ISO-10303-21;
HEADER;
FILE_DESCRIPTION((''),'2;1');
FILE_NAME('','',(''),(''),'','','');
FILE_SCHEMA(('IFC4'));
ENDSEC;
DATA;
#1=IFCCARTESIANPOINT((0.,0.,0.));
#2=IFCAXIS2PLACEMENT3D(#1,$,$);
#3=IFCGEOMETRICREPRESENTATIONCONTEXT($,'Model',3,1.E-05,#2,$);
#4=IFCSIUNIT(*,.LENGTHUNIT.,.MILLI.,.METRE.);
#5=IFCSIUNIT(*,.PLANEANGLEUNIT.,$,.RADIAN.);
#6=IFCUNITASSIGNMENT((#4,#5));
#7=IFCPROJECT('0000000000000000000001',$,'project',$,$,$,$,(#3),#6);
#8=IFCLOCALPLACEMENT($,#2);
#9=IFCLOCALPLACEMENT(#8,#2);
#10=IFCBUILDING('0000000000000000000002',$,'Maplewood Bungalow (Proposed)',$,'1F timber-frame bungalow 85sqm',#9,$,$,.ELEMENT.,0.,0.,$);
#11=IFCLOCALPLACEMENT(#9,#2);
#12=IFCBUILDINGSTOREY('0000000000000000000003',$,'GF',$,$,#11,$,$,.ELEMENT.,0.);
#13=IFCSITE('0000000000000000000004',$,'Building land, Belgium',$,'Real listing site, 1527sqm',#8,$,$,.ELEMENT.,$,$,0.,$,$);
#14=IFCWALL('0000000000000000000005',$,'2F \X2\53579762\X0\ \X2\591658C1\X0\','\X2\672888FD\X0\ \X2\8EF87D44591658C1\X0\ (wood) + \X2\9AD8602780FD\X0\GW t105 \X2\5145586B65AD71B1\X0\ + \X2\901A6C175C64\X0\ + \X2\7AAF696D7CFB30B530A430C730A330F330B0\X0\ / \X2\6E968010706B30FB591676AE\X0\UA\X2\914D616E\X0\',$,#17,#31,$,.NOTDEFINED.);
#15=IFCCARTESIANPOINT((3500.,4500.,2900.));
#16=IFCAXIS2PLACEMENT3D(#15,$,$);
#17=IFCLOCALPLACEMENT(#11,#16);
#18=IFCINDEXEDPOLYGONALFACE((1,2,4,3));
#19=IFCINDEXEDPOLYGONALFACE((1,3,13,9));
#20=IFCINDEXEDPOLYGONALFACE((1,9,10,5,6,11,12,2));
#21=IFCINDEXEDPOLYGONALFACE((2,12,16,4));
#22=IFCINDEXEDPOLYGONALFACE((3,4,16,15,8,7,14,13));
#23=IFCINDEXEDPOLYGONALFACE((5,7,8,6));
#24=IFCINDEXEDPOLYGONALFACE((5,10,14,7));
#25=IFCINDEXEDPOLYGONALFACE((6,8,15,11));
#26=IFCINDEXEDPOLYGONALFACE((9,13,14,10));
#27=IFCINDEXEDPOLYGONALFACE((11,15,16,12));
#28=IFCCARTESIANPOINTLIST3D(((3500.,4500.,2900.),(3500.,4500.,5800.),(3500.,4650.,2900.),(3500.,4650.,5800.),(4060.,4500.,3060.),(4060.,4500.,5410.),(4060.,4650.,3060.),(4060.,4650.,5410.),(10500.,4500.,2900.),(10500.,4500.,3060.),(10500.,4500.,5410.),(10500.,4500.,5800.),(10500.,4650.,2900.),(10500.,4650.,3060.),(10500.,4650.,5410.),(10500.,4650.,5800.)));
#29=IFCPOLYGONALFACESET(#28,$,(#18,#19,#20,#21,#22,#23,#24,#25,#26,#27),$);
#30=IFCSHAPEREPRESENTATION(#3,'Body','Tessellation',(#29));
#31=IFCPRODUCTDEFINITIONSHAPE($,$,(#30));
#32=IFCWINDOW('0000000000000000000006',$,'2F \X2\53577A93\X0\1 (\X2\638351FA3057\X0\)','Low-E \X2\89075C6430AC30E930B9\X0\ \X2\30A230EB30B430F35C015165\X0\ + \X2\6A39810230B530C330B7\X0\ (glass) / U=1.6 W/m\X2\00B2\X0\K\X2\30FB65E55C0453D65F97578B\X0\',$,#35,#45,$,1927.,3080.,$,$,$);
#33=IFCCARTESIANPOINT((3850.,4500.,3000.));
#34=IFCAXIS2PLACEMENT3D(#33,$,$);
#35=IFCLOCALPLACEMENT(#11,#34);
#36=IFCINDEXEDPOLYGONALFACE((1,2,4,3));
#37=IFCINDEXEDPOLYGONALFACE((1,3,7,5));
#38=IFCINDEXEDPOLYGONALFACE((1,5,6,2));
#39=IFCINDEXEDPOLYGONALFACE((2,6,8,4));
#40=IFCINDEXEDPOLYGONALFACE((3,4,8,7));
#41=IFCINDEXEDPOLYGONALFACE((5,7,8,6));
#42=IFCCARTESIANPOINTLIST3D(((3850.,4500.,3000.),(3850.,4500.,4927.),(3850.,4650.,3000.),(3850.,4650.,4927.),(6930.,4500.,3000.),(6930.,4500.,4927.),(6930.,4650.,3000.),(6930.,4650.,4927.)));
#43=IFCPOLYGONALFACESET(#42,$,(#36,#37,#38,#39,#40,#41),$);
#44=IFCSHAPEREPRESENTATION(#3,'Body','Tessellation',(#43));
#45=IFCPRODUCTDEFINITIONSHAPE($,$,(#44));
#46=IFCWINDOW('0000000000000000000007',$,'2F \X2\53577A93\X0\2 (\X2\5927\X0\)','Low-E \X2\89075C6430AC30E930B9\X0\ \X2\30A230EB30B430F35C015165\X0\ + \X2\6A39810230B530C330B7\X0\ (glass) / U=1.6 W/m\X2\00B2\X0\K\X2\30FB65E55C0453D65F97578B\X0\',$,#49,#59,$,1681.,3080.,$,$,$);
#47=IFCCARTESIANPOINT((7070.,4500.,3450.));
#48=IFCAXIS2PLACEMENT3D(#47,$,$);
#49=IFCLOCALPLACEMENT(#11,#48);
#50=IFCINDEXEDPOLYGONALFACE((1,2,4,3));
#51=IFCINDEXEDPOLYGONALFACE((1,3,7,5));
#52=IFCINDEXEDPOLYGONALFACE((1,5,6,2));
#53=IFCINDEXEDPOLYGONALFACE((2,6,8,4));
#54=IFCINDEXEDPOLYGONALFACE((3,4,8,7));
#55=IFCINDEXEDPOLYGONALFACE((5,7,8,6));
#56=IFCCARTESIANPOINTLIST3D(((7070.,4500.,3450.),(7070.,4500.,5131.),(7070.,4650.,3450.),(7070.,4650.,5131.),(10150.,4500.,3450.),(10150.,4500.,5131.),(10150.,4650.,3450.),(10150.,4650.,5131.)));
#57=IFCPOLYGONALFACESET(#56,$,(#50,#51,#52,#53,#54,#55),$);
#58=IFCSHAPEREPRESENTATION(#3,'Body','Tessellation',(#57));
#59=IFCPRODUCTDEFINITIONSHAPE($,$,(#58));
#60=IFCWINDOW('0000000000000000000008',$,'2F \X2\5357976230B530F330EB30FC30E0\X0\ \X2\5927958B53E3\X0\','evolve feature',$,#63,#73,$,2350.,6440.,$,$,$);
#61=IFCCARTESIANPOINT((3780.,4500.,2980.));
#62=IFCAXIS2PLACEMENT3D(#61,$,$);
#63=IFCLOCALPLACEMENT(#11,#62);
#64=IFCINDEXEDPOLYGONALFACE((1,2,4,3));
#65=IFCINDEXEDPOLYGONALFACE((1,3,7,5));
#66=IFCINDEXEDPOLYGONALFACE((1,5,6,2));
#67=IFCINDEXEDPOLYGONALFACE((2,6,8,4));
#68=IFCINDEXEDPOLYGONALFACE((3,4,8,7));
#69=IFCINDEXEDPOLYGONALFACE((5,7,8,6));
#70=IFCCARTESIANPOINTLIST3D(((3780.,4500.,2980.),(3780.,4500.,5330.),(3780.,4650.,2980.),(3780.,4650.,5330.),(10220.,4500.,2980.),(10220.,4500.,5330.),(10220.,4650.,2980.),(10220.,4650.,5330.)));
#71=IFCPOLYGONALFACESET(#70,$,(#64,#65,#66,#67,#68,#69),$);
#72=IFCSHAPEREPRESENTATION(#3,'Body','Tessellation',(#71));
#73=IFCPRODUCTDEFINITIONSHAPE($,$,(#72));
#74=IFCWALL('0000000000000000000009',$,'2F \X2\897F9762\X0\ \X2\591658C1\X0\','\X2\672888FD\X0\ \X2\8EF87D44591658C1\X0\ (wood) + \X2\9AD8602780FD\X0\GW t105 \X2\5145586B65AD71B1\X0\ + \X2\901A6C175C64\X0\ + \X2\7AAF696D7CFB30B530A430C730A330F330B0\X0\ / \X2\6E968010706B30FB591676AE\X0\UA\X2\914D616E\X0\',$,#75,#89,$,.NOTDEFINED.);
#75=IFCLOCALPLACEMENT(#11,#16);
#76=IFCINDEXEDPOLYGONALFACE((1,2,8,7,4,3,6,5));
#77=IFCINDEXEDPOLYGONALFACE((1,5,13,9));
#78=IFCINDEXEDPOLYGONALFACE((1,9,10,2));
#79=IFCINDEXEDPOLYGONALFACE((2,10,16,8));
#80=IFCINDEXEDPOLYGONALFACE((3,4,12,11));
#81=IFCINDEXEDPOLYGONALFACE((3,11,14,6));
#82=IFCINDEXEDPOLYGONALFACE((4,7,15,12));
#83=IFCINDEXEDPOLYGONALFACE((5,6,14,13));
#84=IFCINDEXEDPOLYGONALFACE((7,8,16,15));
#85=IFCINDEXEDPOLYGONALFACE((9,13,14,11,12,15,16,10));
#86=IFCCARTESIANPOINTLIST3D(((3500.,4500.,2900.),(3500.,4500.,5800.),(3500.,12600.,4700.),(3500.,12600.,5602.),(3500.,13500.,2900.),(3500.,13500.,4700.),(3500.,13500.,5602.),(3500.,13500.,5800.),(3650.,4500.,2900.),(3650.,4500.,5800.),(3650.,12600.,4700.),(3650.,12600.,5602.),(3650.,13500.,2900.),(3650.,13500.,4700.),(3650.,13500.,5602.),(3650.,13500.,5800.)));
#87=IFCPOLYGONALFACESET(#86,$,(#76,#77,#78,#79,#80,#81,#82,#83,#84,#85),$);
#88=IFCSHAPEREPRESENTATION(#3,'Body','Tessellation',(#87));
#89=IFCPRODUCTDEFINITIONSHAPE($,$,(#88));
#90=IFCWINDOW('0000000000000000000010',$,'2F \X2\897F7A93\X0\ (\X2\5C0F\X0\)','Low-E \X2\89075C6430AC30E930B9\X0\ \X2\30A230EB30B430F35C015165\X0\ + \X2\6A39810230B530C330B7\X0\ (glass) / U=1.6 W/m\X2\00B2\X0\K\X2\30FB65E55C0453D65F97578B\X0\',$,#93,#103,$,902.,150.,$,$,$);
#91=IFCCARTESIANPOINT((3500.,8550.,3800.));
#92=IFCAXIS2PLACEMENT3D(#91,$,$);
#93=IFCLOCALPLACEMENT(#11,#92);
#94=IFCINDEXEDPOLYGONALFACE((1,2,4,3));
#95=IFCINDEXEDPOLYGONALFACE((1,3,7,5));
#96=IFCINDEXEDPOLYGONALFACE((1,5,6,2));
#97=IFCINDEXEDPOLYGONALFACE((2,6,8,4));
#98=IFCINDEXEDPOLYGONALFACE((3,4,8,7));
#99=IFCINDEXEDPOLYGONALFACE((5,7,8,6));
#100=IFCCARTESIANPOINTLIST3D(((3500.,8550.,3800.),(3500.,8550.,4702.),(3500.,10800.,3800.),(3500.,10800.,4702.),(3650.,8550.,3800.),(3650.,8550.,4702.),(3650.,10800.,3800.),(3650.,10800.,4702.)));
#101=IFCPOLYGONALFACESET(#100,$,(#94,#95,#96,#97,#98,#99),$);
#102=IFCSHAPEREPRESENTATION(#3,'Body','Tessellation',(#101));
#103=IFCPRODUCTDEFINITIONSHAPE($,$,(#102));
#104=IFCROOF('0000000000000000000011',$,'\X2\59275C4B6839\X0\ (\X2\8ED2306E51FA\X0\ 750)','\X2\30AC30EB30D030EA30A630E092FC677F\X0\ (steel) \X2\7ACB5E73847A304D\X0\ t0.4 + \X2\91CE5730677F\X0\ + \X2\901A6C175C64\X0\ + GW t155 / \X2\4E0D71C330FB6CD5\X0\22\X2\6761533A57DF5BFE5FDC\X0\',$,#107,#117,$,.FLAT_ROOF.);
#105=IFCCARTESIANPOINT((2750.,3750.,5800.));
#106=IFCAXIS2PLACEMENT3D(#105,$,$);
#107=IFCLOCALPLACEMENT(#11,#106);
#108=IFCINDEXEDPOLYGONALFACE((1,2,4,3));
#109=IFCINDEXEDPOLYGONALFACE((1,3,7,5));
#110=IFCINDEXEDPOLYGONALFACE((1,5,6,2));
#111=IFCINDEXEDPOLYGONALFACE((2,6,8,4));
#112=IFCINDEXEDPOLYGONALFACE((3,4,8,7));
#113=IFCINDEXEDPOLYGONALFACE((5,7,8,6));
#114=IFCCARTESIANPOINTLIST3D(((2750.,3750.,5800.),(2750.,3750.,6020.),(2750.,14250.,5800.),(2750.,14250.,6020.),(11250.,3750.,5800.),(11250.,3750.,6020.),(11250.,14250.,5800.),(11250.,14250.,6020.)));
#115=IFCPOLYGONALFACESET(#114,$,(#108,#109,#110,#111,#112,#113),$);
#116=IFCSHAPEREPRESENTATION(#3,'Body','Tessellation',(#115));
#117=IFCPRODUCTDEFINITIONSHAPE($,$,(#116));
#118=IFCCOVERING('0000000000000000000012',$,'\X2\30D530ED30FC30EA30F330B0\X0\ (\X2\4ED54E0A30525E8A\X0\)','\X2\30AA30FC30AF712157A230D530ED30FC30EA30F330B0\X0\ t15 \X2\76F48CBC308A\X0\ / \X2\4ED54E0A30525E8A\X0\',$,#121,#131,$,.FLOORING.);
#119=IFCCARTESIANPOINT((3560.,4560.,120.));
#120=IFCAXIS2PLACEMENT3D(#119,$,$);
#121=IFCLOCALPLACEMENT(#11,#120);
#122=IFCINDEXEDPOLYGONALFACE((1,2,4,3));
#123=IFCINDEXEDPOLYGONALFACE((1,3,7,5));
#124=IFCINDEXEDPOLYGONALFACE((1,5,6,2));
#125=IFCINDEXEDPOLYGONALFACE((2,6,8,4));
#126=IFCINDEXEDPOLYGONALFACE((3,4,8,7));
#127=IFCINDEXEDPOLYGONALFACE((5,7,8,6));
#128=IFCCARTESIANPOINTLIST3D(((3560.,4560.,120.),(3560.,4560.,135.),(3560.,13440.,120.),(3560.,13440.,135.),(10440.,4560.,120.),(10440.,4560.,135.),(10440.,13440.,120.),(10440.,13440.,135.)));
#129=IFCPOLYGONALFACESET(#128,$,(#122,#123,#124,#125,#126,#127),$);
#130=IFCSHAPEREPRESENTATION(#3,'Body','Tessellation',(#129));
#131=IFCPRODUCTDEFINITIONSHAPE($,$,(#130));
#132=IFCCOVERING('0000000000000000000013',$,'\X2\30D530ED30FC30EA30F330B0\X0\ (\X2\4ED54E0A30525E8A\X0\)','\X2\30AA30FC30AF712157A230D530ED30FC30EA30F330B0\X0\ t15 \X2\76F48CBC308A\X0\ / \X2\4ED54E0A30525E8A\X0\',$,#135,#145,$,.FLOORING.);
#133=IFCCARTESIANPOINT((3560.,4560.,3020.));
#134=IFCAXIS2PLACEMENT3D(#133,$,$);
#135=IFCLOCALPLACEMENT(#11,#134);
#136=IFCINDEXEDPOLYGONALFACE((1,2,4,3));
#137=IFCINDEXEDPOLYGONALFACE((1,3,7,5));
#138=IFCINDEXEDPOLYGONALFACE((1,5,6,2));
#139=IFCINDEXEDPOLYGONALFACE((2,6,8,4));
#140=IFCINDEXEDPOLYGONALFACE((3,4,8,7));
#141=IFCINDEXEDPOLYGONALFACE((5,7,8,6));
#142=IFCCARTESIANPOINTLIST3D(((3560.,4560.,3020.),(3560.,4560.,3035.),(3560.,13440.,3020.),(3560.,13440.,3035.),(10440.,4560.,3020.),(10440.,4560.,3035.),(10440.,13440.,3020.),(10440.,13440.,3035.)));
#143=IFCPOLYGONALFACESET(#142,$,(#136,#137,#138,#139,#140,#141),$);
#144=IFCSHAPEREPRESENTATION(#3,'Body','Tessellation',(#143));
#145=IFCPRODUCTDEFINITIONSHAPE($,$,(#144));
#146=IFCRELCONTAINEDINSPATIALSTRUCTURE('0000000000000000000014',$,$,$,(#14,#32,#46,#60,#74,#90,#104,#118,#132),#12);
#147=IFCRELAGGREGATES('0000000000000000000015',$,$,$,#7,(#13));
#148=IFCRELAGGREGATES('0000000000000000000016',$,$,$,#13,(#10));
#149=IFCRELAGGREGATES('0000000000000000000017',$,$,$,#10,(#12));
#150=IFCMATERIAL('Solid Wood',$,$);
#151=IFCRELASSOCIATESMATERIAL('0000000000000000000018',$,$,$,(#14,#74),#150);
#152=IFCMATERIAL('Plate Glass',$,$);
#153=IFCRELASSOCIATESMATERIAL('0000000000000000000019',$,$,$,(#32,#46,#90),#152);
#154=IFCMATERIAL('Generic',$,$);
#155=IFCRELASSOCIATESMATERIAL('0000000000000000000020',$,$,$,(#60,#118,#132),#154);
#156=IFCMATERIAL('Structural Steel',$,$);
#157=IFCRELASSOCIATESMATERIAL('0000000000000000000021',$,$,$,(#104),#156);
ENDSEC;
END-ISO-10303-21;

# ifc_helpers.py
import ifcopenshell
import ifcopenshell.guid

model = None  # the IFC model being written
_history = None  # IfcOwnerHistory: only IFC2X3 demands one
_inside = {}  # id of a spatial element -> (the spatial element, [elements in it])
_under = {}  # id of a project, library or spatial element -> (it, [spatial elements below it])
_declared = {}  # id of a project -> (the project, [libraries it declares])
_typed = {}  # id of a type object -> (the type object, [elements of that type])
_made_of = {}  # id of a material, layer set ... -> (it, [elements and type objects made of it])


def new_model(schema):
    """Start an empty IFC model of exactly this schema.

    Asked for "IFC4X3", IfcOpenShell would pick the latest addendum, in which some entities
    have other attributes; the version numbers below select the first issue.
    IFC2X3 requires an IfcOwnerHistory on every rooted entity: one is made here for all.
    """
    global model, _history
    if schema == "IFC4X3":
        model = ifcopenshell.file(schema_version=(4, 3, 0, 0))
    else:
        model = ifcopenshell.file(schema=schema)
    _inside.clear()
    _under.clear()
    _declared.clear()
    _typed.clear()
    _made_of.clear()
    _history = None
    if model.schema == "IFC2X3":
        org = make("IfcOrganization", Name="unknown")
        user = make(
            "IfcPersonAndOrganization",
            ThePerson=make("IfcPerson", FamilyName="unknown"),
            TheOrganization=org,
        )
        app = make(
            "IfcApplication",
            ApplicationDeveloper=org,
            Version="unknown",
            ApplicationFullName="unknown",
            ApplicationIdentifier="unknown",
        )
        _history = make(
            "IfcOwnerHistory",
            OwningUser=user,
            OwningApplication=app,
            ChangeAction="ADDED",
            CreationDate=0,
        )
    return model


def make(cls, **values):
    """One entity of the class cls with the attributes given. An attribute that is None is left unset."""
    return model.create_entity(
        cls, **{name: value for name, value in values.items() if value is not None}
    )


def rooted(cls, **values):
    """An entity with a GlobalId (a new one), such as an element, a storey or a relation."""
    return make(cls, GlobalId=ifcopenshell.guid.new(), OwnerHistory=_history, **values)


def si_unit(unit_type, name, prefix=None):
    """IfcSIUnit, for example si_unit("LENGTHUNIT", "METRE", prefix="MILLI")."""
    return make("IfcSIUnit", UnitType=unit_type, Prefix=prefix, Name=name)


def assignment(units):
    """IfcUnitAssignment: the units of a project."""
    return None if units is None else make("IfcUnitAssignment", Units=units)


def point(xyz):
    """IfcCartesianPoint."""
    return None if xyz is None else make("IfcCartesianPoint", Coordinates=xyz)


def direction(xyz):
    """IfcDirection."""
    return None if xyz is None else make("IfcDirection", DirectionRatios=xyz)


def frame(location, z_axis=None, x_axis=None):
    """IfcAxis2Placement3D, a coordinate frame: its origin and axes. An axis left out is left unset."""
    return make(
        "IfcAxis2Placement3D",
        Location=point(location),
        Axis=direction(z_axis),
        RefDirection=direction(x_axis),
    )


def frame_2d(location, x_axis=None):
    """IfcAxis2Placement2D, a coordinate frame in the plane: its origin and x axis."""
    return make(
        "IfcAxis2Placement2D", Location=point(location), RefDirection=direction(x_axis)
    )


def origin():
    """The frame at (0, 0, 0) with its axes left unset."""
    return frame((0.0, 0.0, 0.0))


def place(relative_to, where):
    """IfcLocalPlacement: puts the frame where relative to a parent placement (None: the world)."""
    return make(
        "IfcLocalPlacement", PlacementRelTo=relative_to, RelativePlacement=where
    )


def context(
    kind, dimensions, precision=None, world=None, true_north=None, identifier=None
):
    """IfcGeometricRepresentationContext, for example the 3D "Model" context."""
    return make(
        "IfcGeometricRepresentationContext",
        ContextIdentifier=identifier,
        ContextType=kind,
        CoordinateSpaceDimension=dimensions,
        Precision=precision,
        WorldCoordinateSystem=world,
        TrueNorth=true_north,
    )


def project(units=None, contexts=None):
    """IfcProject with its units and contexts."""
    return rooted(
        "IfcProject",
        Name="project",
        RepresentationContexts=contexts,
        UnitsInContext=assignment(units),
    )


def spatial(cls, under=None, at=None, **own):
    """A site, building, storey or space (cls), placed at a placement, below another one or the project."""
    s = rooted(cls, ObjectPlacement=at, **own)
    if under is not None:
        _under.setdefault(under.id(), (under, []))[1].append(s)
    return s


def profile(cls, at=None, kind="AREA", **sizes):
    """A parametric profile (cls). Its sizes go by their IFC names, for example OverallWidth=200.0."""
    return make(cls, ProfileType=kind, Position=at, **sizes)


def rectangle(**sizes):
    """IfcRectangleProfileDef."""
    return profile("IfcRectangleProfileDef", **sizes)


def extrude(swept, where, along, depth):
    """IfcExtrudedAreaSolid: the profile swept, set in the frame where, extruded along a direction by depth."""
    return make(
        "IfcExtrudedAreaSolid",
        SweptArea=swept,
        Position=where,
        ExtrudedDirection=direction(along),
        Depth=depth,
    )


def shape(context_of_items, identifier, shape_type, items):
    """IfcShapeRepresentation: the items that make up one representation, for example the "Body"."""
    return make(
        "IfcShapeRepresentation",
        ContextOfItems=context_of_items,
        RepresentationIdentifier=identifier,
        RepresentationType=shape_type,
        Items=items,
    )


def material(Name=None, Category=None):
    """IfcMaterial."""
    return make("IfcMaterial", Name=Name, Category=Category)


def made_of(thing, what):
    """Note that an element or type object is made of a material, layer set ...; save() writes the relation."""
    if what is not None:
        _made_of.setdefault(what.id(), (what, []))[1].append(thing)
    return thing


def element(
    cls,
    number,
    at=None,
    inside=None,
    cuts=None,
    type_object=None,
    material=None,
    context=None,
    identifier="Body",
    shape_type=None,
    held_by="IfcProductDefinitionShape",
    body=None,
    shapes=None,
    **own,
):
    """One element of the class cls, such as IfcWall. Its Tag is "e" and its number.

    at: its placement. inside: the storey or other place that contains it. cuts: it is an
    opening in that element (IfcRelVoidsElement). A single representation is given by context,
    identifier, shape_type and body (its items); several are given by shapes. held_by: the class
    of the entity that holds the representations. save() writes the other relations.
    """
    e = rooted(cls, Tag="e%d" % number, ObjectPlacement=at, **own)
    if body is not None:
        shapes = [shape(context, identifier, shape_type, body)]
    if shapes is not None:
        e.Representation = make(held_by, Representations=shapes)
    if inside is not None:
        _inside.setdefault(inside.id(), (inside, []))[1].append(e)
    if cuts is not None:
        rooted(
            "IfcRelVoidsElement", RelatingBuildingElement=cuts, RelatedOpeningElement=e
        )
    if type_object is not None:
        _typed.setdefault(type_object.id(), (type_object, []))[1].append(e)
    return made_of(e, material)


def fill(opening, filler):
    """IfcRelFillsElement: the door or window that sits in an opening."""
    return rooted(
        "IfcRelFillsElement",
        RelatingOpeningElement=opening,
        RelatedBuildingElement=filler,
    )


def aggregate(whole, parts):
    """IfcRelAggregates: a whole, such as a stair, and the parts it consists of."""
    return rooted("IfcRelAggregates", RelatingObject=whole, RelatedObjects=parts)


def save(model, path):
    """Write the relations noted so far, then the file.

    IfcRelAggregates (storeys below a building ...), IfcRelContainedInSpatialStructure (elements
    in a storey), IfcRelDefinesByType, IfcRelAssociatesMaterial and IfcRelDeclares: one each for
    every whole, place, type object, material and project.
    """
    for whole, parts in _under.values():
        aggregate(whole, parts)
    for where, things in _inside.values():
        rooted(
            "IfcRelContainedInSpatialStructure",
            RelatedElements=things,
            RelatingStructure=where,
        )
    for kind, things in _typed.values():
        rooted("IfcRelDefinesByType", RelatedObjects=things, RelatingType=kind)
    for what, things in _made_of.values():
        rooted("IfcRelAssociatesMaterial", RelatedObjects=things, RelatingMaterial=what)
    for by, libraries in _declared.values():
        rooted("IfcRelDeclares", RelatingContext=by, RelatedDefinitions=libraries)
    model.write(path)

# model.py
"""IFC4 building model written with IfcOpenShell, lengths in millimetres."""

from ifc_helpers import new_model, si_unit, frame, frame_2d, origin, place, context, project, spatial, rectangle, extrude, material, element, fill, save


model = new_model("IFC4")

# Units and contexts
model_context = context("Model", 3, precision=1e-05, world=origin())
ifc_project = project(units=[si_unit("LENGTHUNIT", "METRE", prefix="MILLI"), si_unit("PLANEANGLEUNIT", "RADIAN")], contexts=[model_context])

# Site, building, storey
site_placement = place(None, origin())
site = spatial("IfcSite", under=ifc_project, at=site_placement, Name="Building land, Belgium", ObjectType="Real listing site, 1527sqm", CompositionType="ELEMENT", RefElevation=0.0)
building_placement = place(site_placement, origin())
building = spatial("IfcBuilding", under=site, at=building_placement, Name="Maplewood Bungalow (Proposed)", ObjectType="1F timber-frame bungalow 85sqm", CompositionType="ELEMENT", ElevationOfRefHeight=0.0, ElevationOfTerrain=0.0)
storey_placement = place(building_placement, origin())
storey = spatial("IfcBuildingStorey", under=building, at=storey_placement, Name="GF", CompositionType="ELEMENT", Elevation=0.0)

# Shared definitions
ifc_material_1 = material(Name="Solid Wood")
ifc_material_2 = material(Name="Generic")

# Shared definitions
ifc_material_3 = material(Name="Plate Glass")

# Wall, openings, windows
wall_1_placement = place(storey_placement, frame((3500.0, 4500.0, 2900.0)))
wall_1 = element("IfcWall", 1, at=wall_1_placement, inside=storey, material=ifc_material_1, Name="2F 南面 外壁", Description="木製 軸組外壁 (wood) + 高性能GW t105 充填断熱 + 通気層 + 窯業系サイディング / 準耐火・外皮UA配慮", PredefinedType="NOTDEFINED", context=model_context, shape_type="SweptSolid", body=[
    extrude(rectangle(XDim=7000.0, YDim=150.0, at=frame_2d((3500.0, 75.0))), frame((3500.0, 4500.0, 2900.0)), (0.0, 0.0, 1.0), 2900.0),
])
opening_1_placement = place(storey_placement, frame((3850.0, 4500.0, 3000.0)))
opening_1 = element("IfcOpeningElement", 2, at=opening_1_placement, cuts=wall_1, PredefinedType="NOTDEFINED", context=model_context, shape_type="SweptSolid", body=[
    extrude(rectangle(XDim=3080.0, YDim=150.0, at=frame_2d((1540.0, 75.0))), frame((3850.0, 4500.0, 3000.0)), (0.0, 0.0, 1.0), 1927.0),
])
opening_2_placement = place(storey_placement, frame((7070.0, 4500.0, 3450.0)))
opening_2 = element("IfcOpeningElement", 3, at=opening_2_placement, cuts=wall_1, PredefinedType="NOTDEFINED", context=model_context, shape_type="SweptSolid", body=[
    extrude(rectangle(XDim=3080.0, YDim=150.0, at=frame_2d((1540.0, 75.0))), frame((7070.0, 4500.0, 3450.0)), (0.0, 0.0, 1.0), 1681.0),
])
opening_3_placement = place(storey_placement, frame((3780.0, 4500.0, 2980.0)))
opening_3 = element("IfcOpeningElement", 4, at=opening_3_placement, cuts=wall_1, PredefinedType="NOTDEFINED", context=model_context, shape_type="SweptSolid", body=[
    extrude(rectangle(XDim=6440.0, YDim=150.0, at=frame_2d((3220.0, 75.0))), frame((3780.0, 4500.0, 2980.0)), (0.0, 0.0, 1.0), 2350.0),
])
window_1_placement = place(storey_placement, frame((3850.0, 4500.0, 3000.0)))
window_1 = element("IfcWindow", 5, at=window_1_placement, inside=storey, material=ifc_material_3, Name="2F 南窓1 (掃出し)", Description="Low-E 複層ガラス アルゴン封入 + 樹脂サッシ (glass) / U=1.6 W/m²K・日射取得型", OverallHeight=1927.0, OverallWidth=3080.0, context=model_context, shape_type="SweptSolid", body=[
    extrude(rectangle(XDim=3080.0, YDim=150.0, at=frame_2d((1540.0, 75.0))), frame((3850.0, 4500.0, 3000.0)), (0.0, 0.0, 1.0), 1927.0),
])
fill(opening_1, window_1)
window_2_placement = place(storey_placement, frame((7070.0, 4500.0, 3450.0)))
window_2 = element("IfcWindow", 6, at=window_2_placement, inside=storey, material=ifc_material_3, Name="2F 南窓2 (大)", Description="Low-E 複層ガラス アルゴン封入 + 樹脂サッシ (glass) / U=1.6 W/m²K・日射取得型", OverallHeight=1681.0, OverallWidth=3080.0, context=model_context, shape_type="SweptSolid", body=[
    extrude(rectangle(XDim=3080.0, YDim=150.0, at=frame_2d((1540.0, 75.0))), frame((7070.0, 4500.0, 3450.0)), (0.0, 0.0, 1.0), 1681.0),
])
fill(opening_2, window_2)
window_3_placement = place(storey_placement, frame((3780.0, 4500.0, 2980.0)))
window_3 = element("IfcWindow", 7, at=window_3_placement, inside=storey, material=ifc_material_2, Name="2F 南面サンルーム 大開口", Description="evolve feature", OverallHeight=2350.0, OverallWidth=6440.0, context=model_context, shape_type="SweptSolid", body=[
    extrude(rectangle(XDim=6440.0, YDim=150.0, at=frame_2d((3220.0, 75.0))), frame((3780.0, 4500.0, 2980.0)), (0.0, 0.0, 1.0), 2350.0),
])
fill(opening_3, window_3)

# Wall, opening, window
wall_2_placement = place(storey_placement, frame((3500.0, 4500.0, 2900.0)))
wall_2 = element("IfcWall", 8, at=wall_2_placement, inside=storey, material=ifc_material_1, Name="2F 西面 外壁", Description="木製 軸組外壁 (wood) + 高性能GW t105 充填断熱 + 通気層 + 窯業系サイディング / 準耐火・外皮UA配慮", PredefinedType="NOTDEFINED", context=model_context, shape_type="SweptSolid", body=[
    extrude(rectangle(XDim=150.0, YDim=9000.0, at=frame_2d((75.0, 4500.0))), frame((3500.0, 4500.0, 2900.0)), (0.0, 0.0, 1.0), 2900.0),
])
opening_4_placement = place(storey_placement, frame((3500.0, 8550.0, 3800.0)))
opening_4 = element("IfcOpeningElement", 9, at=opening_4_placement, cuts=wall_2, PredefinedType="NOTDEFINED", context=model_context, shape_type="SweptSolid", body=[
    extrude(rectangle(XDim=150.0, YDim=2250.0, at=frame_2d((75.0, 1125.0))), frame((3500.0, 8550.0, 3800.0)), (0.0, 0.0, 1.0), 902.0),
])
window_4_placement = place(storey_placement, frame((3500.0, 8550.0, 3800.0)))
window_4 = element("IfcWindow", 10, at=window_4_placement, inside=storey, material=ifc_material_3, Name="2F 西窓 (小)", Description="Low-E 複層ガラス アルゴン封入 + 樹脂サッシ (glass) / U=1.6 W/m²K・日射取得型", OverallHeight=902.0, OverallWidth=150.0, context=model_context, shape_type="SweptSolid", body=[
    extrude(rectangle(XDim=150.0, YDim=2250.0, at=frame_2d((75.0, 1125.0))), frame((3500.0, 8550.0, 3800.0)), (0.0, 0.0, 1.0), 902.0),
])
fill(opening_4, window_4)

# Roof
ifc_material_4 = material(Name="Structural Steel")
roof_placement = place(storey_placement, frame((2750.0, 3750.0, 5800.0)))
element("IfcRoof", 11, at=roof_placement, inside=storey, material=ifc_material_4, Name="大屋根 (軒の出 750)", Description="ガルバリウム鋼板 (steel) 立平葺き t0.4 + 野地板 + 通気層 + GW t155 / 不燃・法22条区域対応", PredefinedType="FLAT_ROOF", context=model_context, shape_type="SweptSolid", body=[
    extrude(rectangle(XDim=8500.0, YDim=10500.0, at=frame_2d((4250.0, 5250.0))), frame((2750.0, 3750.0, 5800.0)), (0.0, 0.0, 1.0), 220.0),
])

# Coverings
covering_1_placement = place(storey_placement, frame((3560.0, 4560.0, 120.0)))
element("IfcCovering", 12, at=covering_1_placement, inside=storey, material=ifc_material_2, Name="フローリング (仕上げ床)", Description="オーク無垢フローリング t15 直貼り / 仕上げ床", PredefinedType="FLOORING", context=model_context, shape_type="SweptSolid", body=[
    extrude(rectangle(XDim=6880.0, YDim=8880.0, at=frame_2d((3440.0, 4440.0))), frame((3560.0, 4560.0, 120.0)), (0.0, 0.0, 1.0), 15.0),
])
covering_2_placement = place(storey_placement, frame((3560.0, 4560.0, 3020.0)))
element("IfcCovering", 13, at=covering_2_placement, inside=storey, material=ifc_material_2, Name="フローリング (仕上げ床)", Description="オーク無垢フローリング t15 直貼り / 仕上げ床", PredefinedType="FLOORING", context=model_context, shape_type="SweptSolid", body=[
    extrude(rectangle(XDim=6880.0, YDim=8880.0, at=frame_2d((3440.0, 4440.0))), frame((3560.0, 4560.0, 3020.0)), (0.0, 0.0, 1.0), 15.0),
])

save(model, "model.ifc")
